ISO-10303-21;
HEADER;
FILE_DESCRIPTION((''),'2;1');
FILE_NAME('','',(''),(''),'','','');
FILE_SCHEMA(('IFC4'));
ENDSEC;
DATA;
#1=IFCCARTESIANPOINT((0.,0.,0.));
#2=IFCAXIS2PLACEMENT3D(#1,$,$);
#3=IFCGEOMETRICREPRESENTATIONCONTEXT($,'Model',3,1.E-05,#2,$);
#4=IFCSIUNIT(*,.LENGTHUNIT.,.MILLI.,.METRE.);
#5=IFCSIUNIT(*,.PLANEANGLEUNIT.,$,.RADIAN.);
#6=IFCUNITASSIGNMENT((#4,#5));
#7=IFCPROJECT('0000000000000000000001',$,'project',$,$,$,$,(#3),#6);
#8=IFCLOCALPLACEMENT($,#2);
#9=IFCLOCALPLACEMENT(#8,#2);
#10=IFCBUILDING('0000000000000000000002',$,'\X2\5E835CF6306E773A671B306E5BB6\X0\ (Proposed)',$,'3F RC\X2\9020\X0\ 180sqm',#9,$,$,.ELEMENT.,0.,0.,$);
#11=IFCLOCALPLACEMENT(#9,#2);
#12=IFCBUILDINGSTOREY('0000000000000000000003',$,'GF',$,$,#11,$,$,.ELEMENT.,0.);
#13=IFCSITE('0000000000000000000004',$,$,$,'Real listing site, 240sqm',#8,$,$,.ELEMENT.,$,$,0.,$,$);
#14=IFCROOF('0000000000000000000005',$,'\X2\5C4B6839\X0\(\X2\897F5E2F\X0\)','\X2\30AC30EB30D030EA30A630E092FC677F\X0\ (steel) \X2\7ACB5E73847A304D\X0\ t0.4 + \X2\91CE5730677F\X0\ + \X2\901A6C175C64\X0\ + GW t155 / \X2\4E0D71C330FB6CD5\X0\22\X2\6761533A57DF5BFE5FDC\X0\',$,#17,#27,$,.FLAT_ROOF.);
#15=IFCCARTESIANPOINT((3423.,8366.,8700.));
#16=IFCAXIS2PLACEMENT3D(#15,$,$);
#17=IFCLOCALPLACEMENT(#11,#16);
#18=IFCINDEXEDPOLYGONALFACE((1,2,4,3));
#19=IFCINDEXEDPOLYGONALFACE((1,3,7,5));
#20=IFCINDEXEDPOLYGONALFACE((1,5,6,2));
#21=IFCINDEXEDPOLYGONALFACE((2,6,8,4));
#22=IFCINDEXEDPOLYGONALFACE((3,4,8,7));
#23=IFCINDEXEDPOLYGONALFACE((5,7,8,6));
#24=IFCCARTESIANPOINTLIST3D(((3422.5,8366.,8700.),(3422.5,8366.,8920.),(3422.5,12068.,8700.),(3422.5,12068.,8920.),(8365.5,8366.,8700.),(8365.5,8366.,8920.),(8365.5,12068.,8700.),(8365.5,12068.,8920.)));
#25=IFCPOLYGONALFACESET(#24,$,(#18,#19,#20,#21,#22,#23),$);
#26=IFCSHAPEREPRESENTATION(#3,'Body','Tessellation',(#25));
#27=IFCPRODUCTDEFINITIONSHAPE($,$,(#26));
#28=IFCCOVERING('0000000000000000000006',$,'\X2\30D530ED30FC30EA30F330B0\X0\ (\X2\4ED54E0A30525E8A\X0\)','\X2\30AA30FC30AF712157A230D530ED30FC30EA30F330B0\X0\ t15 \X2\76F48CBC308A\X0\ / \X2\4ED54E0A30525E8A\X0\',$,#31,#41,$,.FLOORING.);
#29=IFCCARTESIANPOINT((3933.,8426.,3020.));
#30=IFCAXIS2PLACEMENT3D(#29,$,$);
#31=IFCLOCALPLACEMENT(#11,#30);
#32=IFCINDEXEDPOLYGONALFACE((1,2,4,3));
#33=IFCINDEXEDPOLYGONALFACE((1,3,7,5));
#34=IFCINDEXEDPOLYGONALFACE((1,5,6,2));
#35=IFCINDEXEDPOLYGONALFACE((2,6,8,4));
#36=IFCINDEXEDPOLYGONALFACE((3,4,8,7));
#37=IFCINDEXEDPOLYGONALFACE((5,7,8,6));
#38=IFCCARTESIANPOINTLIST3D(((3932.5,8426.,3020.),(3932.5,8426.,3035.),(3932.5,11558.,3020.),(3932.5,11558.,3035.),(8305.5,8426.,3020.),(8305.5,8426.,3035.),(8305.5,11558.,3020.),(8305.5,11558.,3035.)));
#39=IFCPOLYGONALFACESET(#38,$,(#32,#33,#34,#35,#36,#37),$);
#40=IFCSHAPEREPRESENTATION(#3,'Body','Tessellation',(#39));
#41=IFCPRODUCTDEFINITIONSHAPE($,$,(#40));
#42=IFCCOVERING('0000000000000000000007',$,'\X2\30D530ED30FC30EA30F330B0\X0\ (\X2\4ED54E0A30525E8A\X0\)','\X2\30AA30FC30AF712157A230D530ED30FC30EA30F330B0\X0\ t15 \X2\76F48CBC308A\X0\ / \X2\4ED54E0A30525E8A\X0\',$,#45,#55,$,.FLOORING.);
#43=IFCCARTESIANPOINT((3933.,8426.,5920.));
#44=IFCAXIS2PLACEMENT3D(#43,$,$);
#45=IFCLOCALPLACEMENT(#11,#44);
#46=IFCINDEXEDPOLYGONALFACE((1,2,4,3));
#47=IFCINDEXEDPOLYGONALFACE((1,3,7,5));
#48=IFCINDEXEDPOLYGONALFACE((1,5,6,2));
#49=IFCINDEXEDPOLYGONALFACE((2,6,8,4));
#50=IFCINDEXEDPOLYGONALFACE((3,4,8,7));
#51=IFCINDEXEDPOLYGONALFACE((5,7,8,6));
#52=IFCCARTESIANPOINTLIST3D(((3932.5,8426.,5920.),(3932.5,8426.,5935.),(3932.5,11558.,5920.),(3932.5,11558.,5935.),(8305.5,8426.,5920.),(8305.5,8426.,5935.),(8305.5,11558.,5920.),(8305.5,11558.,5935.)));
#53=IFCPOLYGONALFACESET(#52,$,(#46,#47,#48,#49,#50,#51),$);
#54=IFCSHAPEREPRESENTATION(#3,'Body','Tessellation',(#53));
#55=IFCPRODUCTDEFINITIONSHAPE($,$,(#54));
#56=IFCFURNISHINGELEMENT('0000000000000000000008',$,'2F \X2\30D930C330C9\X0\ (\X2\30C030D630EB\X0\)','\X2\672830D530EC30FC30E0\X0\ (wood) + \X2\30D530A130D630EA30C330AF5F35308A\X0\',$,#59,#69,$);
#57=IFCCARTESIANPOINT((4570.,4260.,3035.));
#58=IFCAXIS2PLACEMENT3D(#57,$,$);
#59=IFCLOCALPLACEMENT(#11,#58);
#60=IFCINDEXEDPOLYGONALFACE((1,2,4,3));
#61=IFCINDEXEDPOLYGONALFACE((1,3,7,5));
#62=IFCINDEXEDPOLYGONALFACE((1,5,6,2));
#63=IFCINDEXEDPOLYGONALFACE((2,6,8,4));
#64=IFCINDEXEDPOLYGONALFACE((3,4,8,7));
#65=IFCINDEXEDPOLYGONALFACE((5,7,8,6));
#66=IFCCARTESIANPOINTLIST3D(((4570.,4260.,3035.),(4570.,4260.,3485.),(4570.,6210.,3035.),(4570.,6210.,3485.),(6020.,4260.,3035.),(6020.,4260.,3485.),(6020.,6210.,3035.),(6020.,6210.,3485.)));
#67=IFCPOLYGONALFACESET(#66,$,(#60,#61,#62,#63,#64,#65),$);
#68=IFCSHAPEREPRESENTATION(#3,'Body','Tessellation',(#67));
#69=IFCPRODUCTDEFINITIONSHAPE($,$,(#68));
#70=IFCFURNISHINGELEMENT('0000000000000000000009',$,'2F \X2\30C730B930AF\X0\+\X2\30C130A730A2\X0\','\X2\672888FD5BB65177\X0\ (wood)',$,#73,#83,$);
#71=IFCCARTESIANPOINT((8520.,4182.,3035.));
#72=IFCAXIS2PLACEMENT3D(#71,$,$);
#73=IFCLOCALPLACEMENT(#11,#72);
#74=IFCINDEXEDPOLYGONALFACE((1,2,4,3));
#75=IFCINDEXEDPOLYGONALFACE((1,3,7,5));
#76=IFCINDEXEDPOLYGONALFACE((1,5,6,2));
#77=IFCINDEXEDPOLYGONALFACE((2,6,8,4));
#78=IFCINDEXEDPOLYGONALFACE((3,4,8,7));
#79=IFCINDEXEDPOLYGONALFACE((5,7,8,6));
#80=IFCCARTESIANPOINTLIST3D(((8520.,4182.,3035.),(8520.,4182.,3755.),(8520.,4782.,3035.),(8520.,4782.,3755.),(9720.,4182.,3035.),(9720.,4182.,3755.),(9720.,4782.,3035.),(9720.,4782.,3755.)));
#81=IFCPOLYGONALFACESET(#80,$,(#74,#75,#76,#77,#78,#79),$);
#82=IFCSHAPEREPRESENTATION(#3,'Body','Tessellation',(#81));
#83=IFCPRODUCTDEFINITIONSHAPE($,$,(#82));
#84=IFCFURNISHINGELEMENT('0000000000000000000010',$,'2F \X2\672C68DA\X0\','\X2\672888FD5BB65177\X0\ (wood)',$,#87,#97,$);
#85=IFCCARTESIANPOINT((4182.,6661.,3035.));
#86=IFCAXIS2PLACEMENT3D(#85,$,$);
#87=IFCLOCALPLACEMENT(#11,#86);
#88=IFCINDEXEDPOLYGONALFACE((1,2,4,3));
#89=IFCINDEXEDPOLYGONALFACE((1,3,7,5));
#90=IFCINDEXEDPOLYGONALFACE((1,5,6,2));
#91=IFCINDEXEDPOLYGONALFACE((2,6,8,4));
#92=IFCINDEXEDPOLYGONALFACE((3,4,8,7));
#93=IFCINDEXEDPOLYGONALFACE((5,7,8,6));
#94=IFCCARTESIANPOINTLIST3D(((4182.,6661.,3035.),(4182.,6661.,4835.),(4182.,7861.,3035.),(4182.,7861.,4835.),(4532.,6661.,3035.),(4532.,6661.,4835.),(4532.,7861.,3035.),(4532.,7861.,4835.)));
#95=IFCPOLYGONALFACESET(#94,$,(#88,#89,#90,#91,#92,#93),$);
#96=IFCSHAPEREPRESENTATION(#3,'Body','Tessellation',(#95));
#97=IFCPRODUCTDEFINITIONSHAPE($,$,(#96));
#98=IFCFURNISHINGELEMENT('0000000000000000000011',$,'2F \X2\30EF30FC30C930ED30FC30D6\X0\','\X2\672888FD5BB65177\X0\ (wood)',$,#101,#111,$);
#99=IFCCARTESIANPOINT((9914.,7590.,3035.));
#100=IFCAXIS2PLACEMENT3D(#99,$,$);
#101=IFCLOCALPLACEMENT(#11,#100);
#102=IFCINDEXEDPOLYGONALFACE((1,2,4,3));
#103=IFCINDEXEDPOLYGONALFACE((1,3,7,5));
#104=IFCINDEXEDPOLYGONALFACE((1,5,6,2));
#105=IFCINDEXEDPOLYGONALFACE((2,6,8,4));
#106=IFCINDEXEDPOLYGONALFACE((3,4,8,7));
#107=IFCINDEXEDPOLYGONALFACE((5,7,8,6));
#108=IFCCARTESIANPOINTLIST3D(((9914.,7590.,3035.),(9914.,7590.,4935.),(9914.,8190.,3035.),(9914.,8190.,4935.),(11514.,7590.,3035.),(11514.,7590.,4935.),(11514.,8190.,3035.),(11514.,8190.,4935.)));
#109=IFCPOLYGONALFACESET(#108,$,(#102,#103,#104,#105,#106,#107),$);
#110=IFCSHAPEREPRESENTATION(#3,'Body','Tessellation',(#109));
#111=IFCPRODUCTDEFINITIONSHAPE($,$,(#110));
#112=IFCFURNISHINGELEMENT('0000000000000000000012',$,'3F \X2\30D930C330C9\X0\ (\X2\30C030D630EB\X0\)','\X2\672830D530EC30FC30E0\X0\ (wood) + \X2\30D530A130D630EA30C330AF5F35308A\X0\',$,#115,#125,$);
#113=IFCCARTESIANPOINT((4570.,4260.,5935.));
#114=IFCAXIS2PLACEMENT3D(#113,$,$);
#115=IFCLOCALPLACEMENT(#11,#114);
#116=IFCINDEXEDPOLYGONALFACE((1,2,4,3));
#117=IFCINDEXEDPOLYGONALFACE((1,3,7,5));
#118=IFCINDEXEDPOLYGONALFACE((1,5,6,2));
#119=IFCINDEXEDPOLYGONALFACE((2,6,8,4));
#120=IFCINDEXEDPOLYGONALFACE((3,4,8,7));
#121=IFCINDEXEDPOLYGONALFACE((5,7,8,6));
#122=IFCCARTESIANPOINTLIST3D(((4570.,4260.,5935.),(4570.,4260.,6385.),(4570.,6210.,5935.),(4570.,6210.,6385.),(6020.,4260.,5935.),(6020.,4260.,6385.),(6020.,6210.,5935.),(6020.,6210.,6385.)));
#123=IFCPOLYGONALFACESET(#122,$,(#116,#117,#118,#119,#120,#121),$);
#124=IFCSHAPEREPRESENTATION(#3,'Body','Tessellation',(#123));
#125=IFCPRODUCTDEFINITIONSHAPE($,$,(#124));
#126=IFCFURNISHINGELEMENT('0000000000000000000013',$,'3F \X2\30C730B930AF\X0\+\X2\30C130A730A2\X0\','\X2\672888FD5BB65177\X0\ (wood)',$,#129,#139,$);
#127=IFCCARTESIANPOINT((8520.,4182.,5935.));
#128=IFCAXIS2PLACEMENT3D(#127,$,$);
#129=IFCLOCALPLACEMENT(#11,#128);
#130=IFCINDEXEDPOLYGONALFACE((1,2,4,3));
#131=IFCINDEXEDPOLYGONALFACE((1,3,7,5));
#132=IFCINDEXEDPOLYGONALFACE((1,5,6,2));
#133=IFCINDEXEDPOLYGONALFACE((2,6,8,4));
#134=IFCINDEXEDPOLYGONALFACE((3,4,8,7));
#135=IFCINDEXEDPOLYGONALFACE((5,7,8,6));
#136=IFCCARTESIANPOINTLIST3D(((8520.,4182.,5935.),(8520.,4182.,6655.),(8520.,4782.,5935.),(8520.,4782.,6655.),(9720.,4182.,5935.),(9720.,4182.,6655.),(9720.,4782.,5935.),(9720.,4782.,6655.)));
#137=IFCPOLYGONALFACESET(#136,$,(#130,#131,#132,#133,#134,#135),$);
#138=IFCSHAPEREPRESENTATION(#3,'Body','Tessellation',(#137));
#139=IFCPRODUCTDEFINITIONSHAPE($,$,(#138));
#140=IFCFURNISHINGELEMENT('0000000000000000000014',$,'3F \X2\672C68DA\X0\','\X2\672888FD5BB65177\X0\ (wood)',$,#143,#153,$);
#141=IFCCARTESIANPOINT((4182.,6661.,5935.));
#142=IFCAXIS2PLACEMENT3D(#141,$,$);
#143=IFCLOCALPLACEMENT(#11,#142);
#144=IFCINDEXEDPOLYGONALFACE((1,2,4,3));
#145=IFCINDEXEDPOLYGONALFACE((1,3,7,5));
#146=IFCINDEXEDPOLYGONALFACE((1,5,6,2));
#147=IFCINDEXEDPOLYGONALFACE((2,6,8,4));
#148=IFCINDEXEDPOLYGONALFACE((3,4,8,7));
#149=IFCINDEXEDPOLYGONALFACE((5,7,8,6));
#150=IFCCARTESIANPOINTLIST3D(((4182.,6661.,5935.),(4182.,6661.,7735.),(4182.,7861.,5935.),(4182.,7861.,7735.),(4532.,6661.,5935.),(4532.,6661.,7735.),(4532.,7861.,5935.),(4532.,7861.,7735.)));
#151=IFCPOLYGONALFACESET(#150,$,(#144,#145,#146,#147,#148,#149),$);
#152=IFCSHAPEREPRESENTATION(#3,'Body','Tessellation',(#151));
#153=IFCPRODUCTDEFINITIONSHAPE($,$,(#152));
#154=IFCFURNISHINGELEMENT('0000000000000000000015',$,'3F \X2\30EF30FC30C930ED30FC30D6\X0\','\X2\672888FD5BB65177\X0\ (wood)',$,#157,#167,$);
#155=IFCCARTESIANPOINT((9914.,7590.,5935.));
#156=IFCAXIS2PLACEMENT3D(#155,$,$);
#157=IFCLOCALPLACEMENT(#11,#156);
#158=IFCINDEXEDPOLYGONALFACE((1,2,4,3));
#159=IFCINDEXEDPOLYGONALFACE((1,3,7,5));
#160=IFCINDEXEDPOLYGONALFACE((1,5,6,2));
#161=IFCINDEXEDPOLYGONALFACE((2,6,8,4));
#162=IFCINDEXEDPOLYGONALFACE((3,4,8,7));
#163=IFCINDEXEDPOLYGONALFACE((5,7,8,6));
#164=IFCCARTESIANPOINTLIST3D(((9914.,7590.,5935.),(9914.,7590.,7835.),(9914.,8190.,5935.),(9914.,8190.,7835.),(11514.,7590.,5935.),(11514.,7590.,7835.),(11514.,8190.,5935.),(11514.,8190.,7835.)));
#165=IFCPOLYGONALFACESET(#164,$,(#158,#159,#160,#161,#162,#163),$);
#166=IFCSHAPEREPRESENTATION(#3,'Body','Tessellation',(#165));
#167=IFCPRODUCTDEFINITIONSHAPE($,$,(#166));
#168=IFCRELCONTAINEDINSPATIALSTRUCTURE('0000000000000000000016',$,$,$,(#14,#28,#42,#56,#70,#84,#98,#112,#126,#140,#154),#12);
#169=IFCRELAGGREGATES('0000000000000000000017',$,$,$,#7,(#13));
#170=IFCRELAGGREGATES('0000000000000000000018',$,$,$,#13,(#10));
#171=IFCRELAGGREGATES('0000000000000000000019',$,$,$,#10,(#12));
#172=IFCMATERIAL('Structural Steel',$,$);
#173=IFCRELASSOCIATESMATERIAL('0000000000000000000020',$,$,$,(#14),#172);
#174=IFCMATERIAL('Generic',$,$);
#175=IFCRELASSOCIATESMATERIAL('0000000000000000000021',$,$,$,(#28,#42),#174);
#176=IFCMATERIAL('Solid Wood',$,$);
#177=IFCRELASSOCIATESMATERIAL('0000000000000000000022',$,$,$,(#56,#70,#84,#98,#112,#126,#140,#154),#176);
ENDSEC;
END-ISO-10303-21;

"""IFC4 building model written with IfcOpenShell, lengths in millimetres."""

from ifc_helpers import new_model, si_unit, frame, frame_2d, origin, place, context, project, spatial, rectangle, extrude, material, element, save


model = new_model("IFC4")

# Units and contexts
model_context = context("Model", 3, precision=1e-05, world=origin())
ifc_project = project(units=[si_unit("LENGTHUNIT", "METRE", prefix="MILLI"), si_unit("PLANEANGLEUNIT", "RADIAN")], contexts=[model_context])

# Site, building, storey
site_placement = place(None, origin())
site = spatial("IfcSite", under=ifc_project, at=site_placement, ObjectType="Real listing site, 240sqm", CompositionType="ELEMENT", RefElevation=0.0)
building_placement = place(site_placement, origin())
building = spatial("IfcBuilding", under=site, at=building_placement, Name="広島の眺望の家 (Proposed)", ObjectType="3F RC造 180sqm", CompositionType="ELEMENT", ElevationOfRefHeight=0.0, ElevationOfTerrain=0.0)
storey_placement = place(building_placement, origin())
storey = spatial("IfcBuildingStorey", under=building, at=storey_placement, Name="GF", CompositionType="ELEMENT", Elevation=0.0)

# Shared definitions
ifc_material_1 = material(Name="Solid Wood")

# Roof
ifc_material_2 = material(Name="Structural Steel")
roof_1_placement = place(storey_placement, frame((3423.0, 8366.0, 8700.0)))
element("IfcRoof", 1, at=roof_1_placement, inside=storey, material=ifc_material_2, Name="屋根(西帯)", Description="ガルバリウム鋼板 (steel) 立平葺き t0.4 + 野地板 + 通気層 + GW t155 / 不燃・法22条区域対応", PredefinedType="FLAT_ROOF", context=model_context, shape_type="SweptSolid", body=[
    extrude(rectangle(XDim=4943.0, YDim=3702.0, at=frame_2d((2471.0, 1851.0))), frame((3423.0, 8366.0, 8700.0)), (0.0, 0.0, 1.0), 220.0),
])

# Coverings
ifc_material_3 = material(Name="Generic")
covering_1_placement = place(storey_placement, frame((3933.0, 8426.0, 3020.0)))
element("IfcCovering", 2, at=covering_1_placement, inside=storey, material=ifc_material_3, Name="フローリング (仕上げ床)", Description="オーク無垢フローリング t15 直貼り / 仕上げ床", PredefinedType="FLOORING", context=model_context, shape_type="SweptSolid", body=[
    extrude(rectangle(XDim=4373.0, YDim=3132.0, at=frame_2d((2186.0, 1566.0))), frame((3933.0, 8426.0, 3020.0)), (0.0, 0.0, 1.0), 15.0),
])
covering_2_placement = place(storey_placement, frame((3933.0, 8426.0, 5920.0)))
element("IfcCovering", 3, at=covering_2_placement, inside=storey, material=ifc_material_3, Name="フローリング (仕上げ床)", Description="オーク無垢フローリング t15 直貼り / 仕上げ床", PredefinedType="FLOORING", context=model_context, shape_type="SweptSolid", body=[
    extrude(rectangle(XDim=4373.0, YDim=3132.0, at=frame_2d((2186.0, 1566.0))), frame((3933.0, 8426.0, 5920.0)), (0.0, 0.0, 1.0), 15.0),
])

# Furnishing elements
furnishing_1_placement = place(storey_placement, frame((4570.0, 4260.0, 3035.0)))
element("IfcFurnishingElement", 4, at=furnishing_1_placement, inside=storey, material=ifc_material_1, Name="2F ベッド (ダブル)", Description="木フレーム (wood) + ファブリック張り", context=model_context, shape_type="SweptSolid", body=[
    extrude(rectangle(XDim=1450.0, YDim=1950.0, at=frame_2d((725.0, 975.0))), frame((4570.0, 4260.0, 3035.0)), (0.0, 0.0, 1.0), 450.0),
])
furnishing_2_placement = place(storey_placement, frame((8520.0, 4182.0, 3035.0)))
element("IfcFurnishingElement", 5, at=furnishing_2_placement, inside=storey, material=ifc_material_1, Name="2F デスク+チェア", Description="木製家具 (wood)", context=model_context, shape_type="SweptSolid", body=[
    extrude(rectangle(XDim=1200.0, YDim=600.0, at=frame_2d((600.0, 300.0))), frame((8520.0, 4182.0, 3035.0)), (0.0, 0.0, 1.0), 720.0),
])
furnishing_3_placement = place(storey_placement, frame((4182.0, 6661.0, 3035.0)))
element("IfcFurnishingElement", 6, at=furnishing_3_placement, inside=storey, material=ifc_material_1, Name="2F 本棚", Description="木製家具 (wood)", context=model_context, shape_type="SweptSolid", body=[
    extrude(rectangle(XDim=350.0, YDim=1200.0, at=frame_2d((175.0, 600.0))), frame((4182.0, 6661.0, 3035.0)), (0.0, 0.0, 1.0), 1800.0),
])
furnishing_4_placement = place(storey_placement, frame((9914.0, 7590.0, 3035.0)))
element("IfcFurnishingElement", 7, at=furnishing_4_placement, inside=storey, material=ifc_material_1, Name="2F ワードローブ", Description="木製家具 (wood)", context=model_context, shape_type="SweptSolid", body=[
    extrude(rectangle(XDim=1600.0, YDim=600.0, at=frame_2d((800.0, 300.0))), frame((9914.0, 7590.0, 3035.0)), (0.0, 0.0, 1.0), 1900.0),
])
furnishing_5_placement = place(storey_placement, frame((4570.0, 4260.0, 5935.0)))
element("IfcFurnishingElement", 8, at=furnishing_5_placement, inside=storey, material=ifc_material_1, Name="3F ベッド (ダブル)", Description="木フレーム (wood) + ファブリック張り", context=model_context, shape_type="SweptSolid", body=[
    extrude(rectangle(XDim=1450.0, YDim=1950.0, at=frame_2d((725.0, 975.0))), frame((4570.0, 4260.0, 5935.0)), (0.0, 0.0, 1.0), 450.0),
])
furnishing_6_placement = place(storey_placement, frame((8520.0, 4182.0, 5935.0)))
element("IfcFurnishingElement", 9, at=furnishing_6_placement, inside=storey, material=ifc_material_1, Name="3F デスク+チェア", Description="木製家具 (wood)", context=model_context, shape_type="SweptSolid", body=[
    extrude(rectangle(XDim=1200.0, YDim=600.0, at=frame_2d((600.0, 300.0))), frame((8520.0, 4182.0, 5935.0)), (0.0, 0.0, 1.0), 720.0),
])
furnishing_7_placement = place(storey_placement, frame((4182.0, 6661.0, 5935.0)))
element("IfcFurnishingElement", 10, at=furnishing_7_placement, inside=storey, material=ifc_material_1, Name="3F 本棚", Description="木製家具 (wood)", context=model_context, shape_type="SweptSolid", body=[
    extrude(rectangle(XDim=350.0, YDim=1200.0, at=frame_2d((175.0, 600.0))), frame((4182.0, 6661.0, 5935.0)), (0.0, 0.0, 1.0), 1800.0),
])
furnishing_8_placement = place(storey_placement, frame((9914.0, 7590.0, 5935.0)))
element("IfcFurnishingElement", 11, at=furnishing_8_placement, inside=storey, material=ifc_material_1, Name="3F ワードローブ", Description="木製家具 (wood)", context=model_context, shape_type="SweptSolid", body=[
    extrude(rectangle(XDim=1600.0, YDim=600.0, at=frame_2d((800.0, 300.0))), frame((9914.0, 7590.0, 5935.0)), (0.0, 0.0, 1.0), 1900.0),
])

save(model, "model.ifc")
